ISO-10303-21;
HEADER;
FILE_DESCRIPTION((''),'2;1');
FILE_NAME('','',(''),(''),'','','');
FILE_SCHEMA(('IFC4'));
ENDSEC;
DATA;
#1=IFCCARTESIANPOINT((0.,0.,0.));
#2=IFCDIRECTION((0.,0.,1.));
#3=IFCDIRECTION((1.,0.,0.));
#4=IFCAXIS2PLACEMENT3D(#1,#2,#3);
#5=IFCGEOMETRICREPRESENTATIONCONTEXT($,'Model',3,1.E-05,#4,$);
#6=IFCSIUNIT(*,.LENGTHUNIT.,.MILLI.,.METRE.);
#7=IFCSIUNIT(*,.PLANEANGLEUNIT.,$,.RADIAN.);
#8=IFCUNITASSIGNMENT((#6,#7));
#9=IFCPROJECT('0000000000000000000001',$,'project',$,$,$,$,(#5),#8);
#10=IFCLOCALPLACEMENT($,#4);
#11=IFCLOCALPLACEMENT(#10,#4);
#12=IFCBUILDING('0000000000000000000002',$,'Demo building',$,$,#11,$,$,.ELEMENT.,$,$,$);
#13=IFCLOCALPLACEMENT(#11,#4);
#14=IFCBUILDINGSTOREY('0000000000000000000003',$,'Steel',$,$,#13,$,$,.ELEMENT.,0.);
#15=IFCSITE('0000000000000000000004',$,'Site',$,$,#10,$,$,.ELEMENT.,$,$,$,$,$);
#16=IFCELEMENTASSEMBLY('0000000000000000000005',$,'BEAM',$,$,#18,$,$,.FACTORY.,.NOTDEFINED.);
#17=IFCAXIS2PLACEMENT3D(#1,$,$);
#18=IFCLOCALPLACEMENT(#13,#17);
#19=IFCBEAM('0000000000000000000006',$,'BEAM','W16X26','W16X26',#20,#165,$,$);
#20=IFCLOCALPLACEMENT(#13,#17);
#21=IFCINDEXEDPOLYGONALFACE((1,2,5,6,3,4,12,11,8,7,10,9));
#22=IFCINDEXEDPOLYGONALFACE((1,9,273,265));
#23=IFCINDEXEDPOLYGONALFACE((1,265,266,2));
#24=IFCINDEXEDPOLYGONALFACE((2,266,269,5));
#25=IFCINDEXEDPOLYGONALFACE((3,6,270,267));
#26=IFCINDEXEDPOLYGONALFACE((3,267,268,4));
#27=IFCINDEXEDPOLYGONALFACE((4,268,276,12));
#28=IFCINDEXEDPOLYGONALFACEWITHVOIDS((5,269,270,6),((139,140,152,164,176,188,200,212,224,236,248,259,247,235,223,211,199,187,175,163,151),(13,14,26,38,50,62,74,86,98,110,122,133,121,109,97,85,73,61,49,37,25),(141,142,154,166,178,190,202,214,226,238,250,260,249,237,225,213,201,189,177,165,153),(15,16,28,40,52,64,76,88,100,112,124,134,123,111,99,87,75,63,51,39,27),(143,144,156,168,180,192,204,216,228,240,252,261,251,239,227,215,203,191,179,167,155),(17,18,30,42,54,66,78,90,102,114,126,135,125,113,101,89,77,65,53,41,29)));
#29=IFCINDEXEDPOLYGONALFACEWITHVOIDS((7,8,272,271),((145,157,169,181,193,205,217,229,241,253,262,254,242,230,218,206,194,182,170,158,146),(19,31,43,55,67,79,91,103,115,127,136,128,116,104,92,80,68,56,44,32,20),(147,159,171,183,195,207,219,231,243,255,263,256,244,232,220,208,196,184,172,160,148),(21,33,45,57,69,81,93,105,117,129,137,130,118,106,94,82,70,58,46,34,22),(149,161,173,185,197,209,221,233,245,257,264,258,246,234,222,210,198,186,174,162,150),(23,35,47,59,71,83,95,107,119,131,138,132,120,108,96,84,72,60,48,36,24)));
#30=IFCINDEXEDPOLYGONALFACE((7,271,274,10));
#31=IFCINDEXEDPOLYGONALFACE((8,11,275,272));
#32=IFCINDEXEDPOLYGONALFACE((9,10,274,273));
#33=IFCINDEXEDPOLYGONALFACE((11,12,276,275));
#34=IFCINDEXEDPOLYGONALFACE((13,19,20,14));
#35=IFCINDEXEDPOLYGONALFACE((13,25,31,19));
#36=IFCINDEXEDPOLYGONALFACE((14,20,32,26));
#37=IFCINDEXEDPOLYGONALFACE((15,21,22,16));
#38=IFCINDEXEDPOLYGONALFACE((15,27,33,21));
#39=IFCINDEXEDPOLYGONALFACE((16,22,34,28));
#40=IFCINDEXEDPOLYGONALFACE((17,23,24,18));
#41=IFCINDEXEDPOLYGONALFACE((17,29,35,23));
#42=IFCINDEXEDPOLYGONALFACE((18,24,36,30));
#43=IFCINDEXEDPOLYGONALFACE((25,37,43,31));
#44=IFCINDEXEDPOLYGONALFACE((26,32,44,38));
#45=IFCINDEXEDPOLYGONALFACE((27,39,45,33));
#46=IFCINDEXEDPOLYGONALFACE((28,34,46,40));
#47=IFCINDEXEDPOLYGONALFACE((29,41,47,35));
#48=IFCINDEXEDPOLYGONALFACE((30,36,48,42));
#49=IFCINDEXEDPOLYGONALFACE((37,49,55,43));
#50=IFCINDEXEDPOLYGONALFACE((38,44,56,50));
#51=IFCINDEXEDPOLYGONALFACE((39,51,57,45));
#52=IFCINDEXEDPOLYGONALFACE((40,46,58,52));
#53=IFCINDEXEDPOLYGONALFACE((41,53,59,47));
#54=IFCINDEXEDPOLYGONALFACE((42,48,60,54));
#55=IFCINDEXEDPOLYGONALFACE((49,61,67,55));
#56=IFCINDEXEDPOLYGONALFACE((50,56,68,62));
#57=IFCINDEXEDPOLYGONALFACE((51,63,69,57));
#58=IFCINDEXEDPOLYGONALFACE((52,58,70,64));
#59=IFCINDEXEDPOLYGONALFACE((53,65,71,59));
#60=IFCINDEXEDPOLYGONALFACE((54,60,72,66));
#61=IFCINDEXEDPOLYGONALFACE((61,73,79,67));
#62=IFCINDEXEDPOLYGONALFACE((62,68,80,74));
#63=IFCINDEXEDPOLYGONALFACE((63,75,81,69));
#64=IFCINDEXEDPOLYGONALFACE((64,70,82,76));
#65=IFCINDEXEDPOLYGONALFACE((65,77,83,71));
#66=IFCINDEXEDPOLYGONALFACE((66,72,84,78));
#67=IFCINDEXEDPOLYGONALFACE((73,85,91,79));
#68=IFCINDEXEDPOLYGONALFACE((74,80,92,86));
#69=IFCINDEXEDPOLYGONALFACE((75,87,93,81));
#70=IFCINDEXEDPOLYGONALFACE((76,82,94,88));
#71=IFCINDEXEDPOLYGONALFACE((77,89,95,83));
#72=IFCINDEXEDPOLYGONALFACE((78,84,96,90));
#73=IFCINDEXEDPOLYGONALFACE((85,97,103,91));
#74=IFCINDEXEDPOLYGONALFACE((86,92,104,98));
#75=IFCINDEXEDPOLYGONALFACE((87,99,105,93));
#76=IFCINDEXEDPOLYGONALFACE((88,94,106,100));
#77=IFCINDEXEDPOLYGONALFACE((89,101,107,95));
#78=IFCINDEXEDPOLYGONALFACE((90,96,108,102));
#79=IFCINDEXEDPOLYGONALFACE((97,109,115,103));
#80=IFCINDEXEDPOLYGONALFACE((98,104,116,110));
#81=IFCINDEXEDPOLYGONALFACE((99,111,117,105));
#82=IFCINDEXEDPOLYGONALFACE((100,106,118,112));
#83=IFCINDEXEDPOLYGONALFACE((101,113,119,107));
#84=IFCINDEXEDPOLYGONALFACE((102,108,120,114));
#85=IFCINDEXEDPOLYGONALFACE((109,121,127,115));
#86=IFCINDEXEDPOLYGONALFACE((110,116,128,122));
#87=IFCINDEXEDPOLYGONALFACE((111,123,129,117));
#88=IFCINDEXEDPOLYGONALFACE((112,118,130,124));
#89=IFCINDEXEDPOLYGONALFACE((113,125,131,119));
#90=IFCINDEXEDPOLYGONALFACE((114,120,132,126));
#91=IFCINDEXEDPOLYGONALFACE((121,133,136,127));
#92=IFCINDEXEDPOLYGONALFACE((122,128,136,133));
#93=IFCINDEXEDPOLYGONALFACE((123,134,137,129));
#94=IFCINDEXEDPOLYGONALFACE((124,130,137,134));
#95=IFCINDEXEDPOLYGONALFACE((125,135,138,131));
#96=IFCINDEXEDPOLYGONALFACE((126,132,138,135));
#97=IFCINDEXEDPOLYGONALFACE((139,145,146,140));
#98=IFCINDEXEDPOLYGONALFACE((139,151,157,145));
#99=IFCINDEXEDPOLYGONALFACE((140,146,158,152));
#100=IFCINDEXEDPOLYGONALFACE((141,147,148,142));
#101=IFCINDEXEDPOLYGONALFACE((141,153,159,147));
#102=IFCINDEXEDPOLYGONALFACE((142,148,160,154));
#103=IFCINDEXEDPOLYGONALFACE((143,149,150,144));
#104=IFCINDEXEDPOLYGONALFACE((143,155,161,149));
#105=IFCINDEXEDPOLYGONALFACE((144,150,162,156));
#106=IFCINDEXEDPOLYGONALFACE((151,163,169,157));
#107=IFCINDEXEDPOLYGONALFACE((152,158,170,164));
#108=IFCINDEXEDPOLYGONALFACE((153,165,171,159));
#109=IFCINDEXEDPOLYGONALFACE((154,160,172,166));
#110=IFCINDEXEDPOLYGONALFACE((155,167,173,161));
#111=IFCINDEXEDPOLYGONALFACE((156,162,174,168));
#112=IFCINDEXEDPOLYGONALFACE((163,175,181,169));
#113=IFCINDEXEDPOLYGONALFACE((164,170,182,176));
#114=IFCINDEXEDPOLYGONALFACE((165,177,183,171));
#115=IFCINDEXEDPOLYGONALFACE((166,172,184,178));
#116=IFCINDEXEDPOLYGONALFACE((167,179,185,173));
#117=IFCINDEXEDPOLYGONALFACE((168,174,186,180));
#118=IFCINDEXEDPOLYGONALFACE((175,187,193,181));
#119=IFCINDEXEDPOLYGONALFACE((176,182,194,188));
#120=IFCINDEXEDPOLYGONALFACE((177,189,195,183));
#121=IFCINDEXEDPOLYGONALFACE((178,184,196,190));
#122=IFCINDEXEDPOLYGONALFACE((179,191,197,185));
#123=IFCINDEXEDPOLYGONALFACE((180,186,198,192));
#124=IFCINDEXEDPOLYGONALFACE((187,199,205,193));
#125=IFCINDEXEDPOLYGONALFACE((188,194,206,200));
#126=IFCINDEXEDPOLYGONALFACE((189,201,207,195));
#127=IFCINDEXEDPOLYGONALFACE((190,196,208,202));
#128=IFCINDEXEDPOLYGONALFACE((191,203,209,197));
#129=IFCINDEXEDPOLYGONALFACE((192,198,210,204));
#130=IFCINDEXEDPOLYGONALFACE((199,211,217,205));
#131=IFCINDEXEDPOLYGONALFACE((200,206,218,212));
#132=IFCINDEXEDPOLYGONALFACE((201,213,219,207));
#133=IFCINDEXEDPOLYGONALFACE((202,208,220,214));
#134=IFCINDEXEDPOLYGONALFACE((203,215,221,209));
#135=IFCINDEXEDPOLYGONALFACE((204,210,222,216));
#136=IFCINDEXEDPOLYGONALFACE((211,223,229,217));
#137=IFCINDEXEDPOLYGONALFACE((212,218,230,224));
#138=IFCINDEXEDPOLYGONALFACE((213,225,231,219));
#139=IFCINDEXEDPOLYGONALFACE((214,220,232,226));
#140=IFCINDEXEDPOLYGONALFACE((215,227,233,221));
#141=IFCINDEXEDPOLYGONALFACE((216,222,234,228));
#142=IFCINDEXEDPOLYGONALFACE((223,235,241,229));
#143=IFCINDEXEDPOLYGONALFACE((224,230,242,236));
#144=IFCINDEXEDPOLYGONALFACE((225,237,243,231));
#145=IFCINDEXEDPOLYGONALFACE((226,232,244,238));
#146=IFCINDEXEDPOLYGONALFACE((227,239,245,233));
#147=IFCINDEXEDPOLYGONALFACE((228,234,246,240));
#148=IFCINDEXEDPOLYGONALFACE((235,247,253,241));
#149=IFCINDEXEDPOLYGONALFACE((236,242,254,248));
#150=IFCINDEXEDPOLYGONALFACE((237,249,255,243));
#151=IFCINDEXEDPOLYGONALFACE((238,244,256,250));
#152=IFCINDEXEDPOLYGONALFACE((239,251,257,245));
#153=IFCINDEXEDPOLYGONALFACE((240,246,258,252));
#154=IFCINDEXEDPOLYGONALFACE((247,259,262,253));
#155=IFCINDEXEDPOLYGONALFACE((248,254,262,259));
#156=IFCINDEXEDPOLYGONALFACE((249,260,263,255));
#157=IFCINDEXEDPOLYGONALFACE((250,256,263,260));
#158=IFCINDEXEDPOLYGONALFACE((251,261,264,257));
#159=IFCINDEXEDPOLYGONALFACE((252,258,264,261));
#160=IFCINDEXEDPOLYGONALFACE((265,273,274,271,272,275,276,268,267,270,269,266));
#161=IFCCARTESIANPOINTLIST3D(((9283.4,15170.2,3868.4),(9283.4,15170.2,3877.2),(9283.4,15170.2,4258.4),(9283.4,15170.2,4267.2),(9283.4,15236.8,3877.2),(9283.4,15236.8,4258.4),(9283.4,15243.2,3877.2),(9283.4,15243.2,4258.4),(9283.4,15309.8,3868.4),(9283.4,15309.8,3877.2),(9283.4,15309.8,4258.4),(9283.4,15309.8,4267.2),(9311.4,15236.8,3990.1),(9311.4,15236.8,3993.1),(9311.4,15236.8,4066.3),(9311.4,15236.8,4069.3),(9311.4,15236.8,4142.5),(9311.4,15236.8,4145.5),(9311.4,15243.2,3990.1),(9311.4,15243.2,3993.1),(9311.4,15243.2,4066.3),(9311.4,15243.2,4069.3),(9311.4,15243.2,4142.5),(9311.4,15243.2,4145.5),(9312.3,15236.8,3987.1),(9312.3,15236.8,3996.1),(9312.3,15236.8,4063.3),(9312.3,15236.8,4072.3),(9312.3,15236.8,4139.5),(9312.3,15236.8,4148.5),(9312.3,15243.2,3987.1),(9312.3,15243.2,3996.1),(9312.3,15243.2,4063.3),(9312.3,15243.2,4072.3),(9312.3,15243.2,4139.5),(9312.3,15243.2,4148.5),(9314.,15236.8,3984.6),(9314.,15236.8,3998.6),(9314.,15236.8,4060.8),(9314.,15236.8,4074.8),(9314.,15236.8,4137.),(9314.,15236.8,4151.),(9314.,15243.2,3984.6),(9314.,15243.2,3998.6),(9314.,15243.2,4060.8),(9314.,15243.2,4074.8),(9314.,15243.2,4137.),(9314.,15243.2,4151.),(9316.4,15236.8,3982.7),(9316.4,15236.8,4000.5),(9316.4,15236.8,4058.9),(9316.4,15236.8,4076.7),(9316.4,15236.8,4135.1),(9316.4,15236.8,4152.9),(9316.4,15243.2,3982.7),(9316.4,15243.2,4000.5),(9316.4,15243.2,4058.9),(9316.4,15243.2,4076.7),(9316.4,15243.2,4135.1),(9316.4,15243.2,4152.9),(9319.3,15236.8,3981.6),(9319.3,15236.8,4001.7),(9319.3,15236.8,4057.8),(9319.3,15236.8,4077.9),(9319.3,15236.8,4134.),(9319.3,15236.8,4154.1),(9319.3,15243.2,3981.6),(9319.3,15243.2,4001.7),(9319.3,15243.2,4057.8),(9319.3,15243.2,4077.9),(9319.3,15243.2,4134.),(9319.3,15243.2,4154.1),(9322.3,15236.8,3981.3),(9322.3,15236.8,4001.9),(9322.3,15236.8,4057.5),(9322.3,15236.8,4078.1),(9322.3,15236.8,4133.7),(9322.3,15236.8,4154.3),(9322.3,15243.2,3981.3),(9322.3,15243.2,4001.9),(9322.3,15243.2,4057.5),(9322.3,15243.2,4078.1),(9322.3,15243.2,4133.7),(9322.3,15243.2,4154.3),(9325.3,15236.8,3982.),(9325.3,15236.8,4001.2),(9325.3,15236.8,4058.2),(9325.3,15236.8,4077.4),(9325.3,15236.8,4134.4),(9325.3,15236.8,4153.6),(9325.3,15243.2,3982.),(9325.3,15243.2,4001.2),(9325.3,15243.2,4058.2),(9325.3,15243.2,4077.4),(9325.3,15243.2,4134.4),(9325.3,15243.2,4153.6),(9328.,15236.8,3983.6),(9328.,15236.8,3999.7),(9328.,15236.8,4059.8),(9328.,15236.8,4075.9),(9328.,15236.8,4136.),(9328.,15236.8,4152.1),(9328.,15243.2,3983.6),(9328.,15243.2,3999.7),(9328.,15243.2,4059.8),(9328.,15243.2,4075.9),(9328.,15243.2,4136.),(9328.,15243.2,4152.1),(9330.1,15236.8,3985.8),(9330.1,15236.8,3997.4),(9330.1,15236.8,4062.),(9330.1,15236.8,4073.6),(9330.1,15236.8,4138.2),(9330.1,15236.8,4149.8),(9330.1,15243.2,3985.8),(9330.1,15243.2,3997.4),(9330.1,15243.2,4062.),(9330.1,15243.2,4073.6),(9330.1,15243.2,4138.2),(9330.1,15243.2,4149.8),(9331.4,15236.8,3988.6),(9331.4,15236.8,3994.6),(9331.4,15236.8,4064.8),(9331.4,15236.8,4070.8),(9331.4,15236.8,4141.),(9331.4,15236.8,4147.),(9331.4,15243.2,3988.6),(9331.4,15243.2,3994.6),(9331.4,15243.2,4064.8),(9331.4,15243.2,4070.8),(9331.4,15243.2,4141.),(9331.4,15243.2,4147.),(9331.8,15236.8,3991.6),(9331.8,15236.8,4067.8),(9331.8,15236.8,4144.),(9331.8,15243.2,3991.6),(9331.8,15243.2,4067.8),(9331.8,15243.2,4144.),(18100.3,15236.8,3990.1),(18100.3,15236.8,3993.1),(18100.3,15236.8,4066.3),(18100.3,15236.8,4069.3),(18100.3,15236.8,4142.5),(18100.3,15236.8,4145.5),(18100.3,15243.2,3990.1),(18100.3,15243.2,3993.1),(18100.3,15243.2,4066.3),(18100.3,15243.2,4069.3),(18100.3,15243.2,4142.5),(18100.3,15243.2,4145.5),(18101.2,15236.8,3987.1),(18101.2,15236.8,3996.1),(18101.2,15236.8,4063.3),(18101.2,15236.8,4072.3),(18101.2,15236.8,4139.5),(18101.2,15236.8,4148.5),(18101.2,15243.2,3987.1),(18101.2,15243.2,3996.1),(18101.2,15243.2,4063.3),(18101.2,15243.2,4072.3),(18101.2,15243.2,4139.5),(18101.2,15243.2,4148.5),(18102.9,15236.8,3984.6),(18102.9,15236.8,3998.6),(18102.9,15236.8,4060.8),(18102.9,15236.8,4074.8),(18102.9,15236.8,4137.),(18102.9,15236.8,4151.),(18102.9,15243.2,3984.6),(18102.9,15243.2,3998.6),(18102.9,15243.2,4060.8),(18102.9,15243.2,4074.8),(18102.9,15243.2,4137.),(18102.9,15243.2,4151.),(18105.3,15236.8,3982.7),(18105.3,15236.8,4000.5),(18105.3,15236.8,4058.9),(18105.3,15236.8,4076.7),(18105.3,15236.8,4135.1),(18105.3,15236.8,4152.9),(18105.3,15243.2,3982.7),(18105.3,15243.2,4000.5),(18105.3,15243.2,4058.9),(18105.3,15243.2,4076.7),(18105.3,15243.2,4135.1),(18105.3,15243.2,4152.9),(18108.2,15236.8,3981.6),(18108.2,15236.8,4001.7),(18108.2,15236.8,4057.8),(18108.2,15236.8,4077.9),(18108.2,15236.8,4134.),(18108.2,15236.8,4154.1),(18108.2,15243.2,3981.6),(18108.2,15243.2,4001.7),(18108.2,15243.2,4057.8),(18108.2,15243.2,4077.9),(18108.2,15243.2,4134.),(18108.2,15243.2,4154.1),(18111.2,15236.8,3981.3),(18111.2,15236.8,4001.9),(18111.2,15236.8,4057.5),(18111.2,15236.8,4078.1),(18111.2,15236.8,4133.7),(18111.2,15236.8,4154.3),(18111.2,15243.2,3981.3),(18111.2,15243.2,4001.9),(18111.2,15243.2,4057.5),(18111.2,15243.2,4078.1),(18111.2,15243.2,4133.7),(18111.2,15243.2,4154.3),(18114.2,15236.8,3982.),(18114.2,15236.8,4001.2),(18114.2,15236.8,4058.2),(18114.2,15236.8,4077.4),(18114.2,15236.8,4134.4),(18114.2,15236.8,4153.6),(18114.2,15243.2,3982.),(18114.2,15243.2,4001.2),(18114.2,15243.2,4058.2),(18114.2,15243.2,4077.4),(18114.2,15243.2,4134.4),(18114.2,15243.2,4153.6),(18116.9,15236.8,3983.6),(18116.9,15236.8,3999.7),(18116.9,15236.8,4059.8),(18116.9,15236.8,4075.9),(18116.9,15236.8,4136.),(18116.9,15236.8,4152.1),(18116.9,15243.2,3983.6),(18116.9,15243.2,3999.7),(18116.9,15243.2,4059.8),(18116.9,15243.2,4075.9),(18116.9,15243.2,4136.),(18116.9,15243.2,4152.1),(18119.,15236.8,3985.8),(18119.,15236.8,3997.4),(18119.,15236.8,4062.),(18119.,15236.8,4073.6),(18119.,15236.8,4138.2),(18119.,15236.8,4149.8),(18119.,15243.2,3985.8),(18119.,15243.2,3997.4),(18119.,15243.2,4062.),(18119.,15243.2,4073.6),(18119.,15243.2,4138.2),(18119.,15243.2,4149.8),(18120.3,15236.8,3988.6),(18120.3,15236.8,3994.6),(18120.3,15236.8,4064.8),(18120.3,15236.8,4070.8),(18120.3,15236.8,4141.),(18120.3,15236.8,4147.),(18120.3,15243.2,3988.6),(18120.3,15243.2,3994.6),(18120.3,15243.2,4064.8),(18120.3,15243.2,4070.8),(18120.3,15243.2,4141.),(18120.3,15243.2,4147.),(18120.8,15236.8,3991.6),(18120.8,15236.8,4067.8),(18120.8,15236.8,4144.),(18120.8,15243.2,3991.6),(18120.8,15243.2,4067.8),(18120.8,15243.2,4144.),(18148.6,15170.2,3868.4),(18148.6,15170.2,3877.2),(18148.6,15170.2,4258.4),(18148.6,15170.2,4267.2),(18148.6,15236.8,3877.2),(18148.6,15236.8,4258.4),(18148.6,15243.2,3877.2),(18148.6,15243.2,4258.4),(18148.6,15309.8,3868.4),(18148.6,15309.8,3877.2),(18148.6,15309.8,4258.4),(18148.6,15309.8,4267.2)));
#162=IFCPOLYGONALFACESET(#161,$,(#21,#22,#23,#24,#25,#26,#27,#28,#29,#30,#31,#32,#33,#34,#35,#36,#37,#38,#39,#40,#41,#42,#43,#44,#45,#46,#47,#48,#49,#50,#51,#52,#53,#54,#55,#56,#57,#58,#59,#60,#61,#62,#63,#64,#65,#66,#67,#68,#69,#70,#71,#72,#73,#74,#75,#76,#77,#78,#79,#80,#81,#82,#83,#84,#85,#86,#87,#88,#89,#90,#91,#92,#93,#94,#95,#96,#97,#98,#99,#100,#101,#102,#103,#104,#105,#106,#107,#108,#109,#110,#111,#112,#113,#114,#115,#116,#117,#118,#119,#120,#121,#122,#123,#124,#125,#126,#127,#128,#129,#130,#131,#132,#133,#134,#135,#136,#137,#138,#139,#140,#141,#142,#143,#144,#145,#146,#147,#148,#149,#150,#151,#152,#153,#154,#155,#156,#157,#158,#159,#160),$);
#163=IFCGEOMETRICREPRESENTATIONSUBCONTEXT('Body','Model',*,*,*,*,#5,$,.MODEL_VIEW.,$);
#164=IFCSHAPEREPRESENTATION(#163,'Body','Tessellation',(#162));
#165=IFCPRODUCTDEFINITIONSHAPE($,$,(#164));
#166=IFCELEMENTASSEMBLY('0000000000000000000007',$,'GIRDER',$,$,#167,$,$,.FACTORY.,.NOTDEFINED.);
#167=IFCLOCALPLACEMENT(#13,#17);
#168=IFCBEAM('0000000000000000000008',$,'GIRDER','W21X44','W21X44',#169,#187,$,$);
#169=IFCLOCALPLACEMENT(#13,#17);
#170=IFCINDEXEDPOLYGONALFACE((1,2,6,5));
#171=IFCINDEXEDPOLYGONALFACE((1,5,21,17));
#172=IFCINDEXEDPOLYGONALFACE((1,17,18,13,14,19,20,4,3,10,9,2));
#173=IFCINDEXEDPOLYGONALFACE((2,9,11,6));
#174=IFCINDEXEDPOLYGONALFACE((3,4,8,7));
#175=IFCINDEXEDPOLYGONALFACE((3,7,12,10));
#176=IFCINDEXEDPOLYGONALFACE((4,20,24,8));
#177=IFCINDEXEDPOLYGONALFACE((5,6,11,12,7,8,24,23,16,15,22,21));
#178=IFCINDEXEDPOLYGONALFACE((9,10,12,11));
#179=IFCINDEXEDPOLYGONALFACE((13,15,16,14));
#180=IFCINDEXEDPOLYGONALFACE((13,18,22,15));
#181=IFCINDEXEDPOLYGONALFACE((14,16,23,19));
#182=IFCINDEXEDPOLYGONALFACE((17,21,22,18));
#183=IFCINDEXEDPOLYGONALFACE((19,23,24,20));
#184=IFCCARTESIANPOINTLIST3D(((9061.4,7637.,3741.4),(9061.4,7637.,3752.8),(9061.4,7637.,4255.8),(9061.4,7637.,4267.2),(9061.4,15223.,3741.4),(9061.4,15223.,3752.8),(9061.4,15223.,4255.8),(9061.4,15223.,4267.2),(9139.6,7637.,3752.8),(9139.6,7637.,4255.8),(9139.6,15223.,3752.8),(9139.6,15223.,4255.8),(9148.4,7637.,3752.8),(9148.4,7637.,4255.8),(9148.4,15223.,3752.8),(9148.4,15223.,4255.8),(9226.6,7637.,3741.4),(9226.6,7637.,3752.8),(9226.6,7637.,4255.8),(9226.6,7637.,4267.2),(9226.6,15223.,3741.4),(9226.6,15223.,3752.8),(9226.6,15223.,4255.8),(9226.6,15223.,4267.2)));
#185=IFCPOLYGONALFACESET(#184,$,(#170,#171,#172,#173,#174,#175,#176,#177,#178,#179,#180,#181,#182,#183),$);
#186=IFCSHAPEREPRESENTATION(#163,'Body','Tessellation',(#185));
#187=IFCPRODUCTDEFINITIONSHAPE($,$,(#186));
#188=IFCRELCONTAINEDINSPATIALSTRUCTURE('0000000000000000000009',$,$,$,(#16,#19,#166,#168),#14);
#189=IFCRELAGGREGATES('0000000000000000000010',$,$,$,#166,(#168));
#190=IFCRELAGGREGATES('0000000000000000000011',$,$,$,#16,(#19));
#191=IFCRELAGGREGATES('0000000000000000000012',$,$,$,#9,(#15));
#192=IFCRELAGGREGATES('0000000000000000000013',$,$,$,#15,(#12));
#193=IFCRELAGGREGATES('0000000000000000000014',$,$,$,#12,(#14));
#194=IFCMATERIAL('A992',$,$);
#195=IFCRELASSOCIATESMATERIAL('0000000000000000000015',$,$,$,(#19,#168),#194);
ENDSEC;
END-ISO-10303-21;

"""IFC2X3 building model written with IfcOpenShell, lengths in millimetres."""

from ifc_helpers import new_model, si_unit, frame, origin, origin_with_axes, origin_2d, place, context, subcontext, project, spatial, circle, i_section, extrude, boolean, material, element, aggregate, save


model = new_model("IFC2X3")

# Units and contexts
model_context = context("Model", 3, precision=1e-05, world=origin_with_axes())
body_context = subcontext(model_context, "Body", "Model", "MODEL_VIEW")
ifc_project = project(units=[si_unit("LENGTHUNIT", "METRE", prefix="MILLI"), si_unit("PLANEANGLEUNIT", "RADIAN")], contexts=[model_context])

# Site, building, storey
site_placement = place(None, origin_with_axes())
site = spatial("IfcSite", under=ifc_project, at=site_placement, Name="Site", CompositionType="ELEMENT")
building_placement = place(site_placement, origin_with_axes())
building = spatial("IfcBuilding", under=site, at=building_placement, Name="Demo building", CompositionType="ELEMENT")
placement = place(building_placement, origin_with_axes())
storey = spatial("IfcBuildingStorey", under=building, at=placement, Name="Steel", CompositionType="ELEMENT", Elevation=0.0)

# Shared definitions
ifc_material_1 = material(Name="A992")

# Element assemblies, beams
assembly_1 = element("IfcElementAssembly", 1, at=placement, inside=storey, Name="BEAM", AssemblyPlace="FACTORY", PredefinedType="NOTDEFINED")
beam_1_placement = place(placement, frame((9283.4, 15240.0, 4067.8), z_axis=(1.0, 0.0, 0.0), x_axis=(0.0, 1.0, 0.0)))
beam_1 = element("IfcBeam", 2, at=beam_1_placement, inside=storey, material=ifc_material_1, Name="BEAM", Description="W16X26", ObjectType="W16X26", context=body_context, shape_type="CSG", body=[
    boolean("DIFFERENCE", boolean("DIFFERENCE", boolean("DIFFERENCE", boolean("DIFFERENCE", boolean("DIFFERENCE", boolean("DIFFERENCE", extrude(i_section(OverallWidth=139.7, OverallDepth=398.8, WebThickness=6.3, FlangeThickness=8.8, at=origin_2d()), origin(), (0.0, 0.0, 1.0), 8865.1), extrude(circle(Radius=10.3, at=origin_2d()), frame((-60.0, -76.2, 38.1), z_axis=(1.0, 0.0, 0.0), x_axis=(0.0, 0.0, 1.0)), (0.0, 0.0, 1.0), 120.0)), extrude(circle(Radius=10.3, at=origin_2d()), frame((-60.0, 0.0, 38.1), z_axis=(1.0, 0.0, 0.0), x_axis=(0.0, 0.0, 1.0)), (0.0, 0.0, 1.0), 120.0)), extrude(circle(Radius=10.3, at=origin_2d()), frame((-60.0, 76.2, 38.1), z_axis=(1.0, 0.0, 0.0), x_axis=(0.0, 0.0, 1.0)), (0.0, 0.0, 1.0), 120.0)), extrude(circle(Radius=10.3, at=origin_2d()), frame((-60.0, -76.2, 8827.0), z_axis=(1.0, 0.0, 0.0), x_axis=(0.0, 0.0, 1.0)), (0.0, 0.0, 1.0), 120.0)), extrude(circle(Radius=10.3, at=origin_2d()), frame((-60.0, 0.0, 8827.0), z_axis=(1.0, 0.0, 0.0), x_axis=(0.0, 0.0, 1.0)), (0.0, 0.0, 1.0), 120.0)), extrude(circle(Radius=10.3, at=origin_2d()), frame((-60.0, 76.2, 8827.0), z_axis=(1.0, 0.0, 0.0), x_axis=(0.0, 0.0, 1.0)), (0.0, 0.0, 1.0), 120.0)),
])
assembly_2 = element("IfcElementAssembly", 3, at=placement, inside=storey, Name="GIRDER", AssemblyPlace="FACTORY", PredefinedType="NOTDEFINED")
beam_2_placement = place(placement, frame((9144.0, 7637.0, 4004.3), z_axis=(0.0, 1.0, 0.0), x_axis=(-1.0, 0.0, 0.0)))
beam_2 = element("IfcBeam", 4, at=beam_2_placement, inside=storey, material=ifc_material_1, Name="GIRDER", Description="W21X44", ObjectType="W21X44", context=body_context, shape_type="SweptSolid", body=[
    extrude(i_section(OverallWidth=165.1, OverallDepth=525.8, WebThickness=8.9, FlangeThickness=11.4, at=origin_2d()), origin(), (0.0, 0.0, 1.0), 7586.0),
])
aggregate(assembly_2, [beam_2])

aggregate(assembly_1, [beam_1])

save(model, "model.ifc")
